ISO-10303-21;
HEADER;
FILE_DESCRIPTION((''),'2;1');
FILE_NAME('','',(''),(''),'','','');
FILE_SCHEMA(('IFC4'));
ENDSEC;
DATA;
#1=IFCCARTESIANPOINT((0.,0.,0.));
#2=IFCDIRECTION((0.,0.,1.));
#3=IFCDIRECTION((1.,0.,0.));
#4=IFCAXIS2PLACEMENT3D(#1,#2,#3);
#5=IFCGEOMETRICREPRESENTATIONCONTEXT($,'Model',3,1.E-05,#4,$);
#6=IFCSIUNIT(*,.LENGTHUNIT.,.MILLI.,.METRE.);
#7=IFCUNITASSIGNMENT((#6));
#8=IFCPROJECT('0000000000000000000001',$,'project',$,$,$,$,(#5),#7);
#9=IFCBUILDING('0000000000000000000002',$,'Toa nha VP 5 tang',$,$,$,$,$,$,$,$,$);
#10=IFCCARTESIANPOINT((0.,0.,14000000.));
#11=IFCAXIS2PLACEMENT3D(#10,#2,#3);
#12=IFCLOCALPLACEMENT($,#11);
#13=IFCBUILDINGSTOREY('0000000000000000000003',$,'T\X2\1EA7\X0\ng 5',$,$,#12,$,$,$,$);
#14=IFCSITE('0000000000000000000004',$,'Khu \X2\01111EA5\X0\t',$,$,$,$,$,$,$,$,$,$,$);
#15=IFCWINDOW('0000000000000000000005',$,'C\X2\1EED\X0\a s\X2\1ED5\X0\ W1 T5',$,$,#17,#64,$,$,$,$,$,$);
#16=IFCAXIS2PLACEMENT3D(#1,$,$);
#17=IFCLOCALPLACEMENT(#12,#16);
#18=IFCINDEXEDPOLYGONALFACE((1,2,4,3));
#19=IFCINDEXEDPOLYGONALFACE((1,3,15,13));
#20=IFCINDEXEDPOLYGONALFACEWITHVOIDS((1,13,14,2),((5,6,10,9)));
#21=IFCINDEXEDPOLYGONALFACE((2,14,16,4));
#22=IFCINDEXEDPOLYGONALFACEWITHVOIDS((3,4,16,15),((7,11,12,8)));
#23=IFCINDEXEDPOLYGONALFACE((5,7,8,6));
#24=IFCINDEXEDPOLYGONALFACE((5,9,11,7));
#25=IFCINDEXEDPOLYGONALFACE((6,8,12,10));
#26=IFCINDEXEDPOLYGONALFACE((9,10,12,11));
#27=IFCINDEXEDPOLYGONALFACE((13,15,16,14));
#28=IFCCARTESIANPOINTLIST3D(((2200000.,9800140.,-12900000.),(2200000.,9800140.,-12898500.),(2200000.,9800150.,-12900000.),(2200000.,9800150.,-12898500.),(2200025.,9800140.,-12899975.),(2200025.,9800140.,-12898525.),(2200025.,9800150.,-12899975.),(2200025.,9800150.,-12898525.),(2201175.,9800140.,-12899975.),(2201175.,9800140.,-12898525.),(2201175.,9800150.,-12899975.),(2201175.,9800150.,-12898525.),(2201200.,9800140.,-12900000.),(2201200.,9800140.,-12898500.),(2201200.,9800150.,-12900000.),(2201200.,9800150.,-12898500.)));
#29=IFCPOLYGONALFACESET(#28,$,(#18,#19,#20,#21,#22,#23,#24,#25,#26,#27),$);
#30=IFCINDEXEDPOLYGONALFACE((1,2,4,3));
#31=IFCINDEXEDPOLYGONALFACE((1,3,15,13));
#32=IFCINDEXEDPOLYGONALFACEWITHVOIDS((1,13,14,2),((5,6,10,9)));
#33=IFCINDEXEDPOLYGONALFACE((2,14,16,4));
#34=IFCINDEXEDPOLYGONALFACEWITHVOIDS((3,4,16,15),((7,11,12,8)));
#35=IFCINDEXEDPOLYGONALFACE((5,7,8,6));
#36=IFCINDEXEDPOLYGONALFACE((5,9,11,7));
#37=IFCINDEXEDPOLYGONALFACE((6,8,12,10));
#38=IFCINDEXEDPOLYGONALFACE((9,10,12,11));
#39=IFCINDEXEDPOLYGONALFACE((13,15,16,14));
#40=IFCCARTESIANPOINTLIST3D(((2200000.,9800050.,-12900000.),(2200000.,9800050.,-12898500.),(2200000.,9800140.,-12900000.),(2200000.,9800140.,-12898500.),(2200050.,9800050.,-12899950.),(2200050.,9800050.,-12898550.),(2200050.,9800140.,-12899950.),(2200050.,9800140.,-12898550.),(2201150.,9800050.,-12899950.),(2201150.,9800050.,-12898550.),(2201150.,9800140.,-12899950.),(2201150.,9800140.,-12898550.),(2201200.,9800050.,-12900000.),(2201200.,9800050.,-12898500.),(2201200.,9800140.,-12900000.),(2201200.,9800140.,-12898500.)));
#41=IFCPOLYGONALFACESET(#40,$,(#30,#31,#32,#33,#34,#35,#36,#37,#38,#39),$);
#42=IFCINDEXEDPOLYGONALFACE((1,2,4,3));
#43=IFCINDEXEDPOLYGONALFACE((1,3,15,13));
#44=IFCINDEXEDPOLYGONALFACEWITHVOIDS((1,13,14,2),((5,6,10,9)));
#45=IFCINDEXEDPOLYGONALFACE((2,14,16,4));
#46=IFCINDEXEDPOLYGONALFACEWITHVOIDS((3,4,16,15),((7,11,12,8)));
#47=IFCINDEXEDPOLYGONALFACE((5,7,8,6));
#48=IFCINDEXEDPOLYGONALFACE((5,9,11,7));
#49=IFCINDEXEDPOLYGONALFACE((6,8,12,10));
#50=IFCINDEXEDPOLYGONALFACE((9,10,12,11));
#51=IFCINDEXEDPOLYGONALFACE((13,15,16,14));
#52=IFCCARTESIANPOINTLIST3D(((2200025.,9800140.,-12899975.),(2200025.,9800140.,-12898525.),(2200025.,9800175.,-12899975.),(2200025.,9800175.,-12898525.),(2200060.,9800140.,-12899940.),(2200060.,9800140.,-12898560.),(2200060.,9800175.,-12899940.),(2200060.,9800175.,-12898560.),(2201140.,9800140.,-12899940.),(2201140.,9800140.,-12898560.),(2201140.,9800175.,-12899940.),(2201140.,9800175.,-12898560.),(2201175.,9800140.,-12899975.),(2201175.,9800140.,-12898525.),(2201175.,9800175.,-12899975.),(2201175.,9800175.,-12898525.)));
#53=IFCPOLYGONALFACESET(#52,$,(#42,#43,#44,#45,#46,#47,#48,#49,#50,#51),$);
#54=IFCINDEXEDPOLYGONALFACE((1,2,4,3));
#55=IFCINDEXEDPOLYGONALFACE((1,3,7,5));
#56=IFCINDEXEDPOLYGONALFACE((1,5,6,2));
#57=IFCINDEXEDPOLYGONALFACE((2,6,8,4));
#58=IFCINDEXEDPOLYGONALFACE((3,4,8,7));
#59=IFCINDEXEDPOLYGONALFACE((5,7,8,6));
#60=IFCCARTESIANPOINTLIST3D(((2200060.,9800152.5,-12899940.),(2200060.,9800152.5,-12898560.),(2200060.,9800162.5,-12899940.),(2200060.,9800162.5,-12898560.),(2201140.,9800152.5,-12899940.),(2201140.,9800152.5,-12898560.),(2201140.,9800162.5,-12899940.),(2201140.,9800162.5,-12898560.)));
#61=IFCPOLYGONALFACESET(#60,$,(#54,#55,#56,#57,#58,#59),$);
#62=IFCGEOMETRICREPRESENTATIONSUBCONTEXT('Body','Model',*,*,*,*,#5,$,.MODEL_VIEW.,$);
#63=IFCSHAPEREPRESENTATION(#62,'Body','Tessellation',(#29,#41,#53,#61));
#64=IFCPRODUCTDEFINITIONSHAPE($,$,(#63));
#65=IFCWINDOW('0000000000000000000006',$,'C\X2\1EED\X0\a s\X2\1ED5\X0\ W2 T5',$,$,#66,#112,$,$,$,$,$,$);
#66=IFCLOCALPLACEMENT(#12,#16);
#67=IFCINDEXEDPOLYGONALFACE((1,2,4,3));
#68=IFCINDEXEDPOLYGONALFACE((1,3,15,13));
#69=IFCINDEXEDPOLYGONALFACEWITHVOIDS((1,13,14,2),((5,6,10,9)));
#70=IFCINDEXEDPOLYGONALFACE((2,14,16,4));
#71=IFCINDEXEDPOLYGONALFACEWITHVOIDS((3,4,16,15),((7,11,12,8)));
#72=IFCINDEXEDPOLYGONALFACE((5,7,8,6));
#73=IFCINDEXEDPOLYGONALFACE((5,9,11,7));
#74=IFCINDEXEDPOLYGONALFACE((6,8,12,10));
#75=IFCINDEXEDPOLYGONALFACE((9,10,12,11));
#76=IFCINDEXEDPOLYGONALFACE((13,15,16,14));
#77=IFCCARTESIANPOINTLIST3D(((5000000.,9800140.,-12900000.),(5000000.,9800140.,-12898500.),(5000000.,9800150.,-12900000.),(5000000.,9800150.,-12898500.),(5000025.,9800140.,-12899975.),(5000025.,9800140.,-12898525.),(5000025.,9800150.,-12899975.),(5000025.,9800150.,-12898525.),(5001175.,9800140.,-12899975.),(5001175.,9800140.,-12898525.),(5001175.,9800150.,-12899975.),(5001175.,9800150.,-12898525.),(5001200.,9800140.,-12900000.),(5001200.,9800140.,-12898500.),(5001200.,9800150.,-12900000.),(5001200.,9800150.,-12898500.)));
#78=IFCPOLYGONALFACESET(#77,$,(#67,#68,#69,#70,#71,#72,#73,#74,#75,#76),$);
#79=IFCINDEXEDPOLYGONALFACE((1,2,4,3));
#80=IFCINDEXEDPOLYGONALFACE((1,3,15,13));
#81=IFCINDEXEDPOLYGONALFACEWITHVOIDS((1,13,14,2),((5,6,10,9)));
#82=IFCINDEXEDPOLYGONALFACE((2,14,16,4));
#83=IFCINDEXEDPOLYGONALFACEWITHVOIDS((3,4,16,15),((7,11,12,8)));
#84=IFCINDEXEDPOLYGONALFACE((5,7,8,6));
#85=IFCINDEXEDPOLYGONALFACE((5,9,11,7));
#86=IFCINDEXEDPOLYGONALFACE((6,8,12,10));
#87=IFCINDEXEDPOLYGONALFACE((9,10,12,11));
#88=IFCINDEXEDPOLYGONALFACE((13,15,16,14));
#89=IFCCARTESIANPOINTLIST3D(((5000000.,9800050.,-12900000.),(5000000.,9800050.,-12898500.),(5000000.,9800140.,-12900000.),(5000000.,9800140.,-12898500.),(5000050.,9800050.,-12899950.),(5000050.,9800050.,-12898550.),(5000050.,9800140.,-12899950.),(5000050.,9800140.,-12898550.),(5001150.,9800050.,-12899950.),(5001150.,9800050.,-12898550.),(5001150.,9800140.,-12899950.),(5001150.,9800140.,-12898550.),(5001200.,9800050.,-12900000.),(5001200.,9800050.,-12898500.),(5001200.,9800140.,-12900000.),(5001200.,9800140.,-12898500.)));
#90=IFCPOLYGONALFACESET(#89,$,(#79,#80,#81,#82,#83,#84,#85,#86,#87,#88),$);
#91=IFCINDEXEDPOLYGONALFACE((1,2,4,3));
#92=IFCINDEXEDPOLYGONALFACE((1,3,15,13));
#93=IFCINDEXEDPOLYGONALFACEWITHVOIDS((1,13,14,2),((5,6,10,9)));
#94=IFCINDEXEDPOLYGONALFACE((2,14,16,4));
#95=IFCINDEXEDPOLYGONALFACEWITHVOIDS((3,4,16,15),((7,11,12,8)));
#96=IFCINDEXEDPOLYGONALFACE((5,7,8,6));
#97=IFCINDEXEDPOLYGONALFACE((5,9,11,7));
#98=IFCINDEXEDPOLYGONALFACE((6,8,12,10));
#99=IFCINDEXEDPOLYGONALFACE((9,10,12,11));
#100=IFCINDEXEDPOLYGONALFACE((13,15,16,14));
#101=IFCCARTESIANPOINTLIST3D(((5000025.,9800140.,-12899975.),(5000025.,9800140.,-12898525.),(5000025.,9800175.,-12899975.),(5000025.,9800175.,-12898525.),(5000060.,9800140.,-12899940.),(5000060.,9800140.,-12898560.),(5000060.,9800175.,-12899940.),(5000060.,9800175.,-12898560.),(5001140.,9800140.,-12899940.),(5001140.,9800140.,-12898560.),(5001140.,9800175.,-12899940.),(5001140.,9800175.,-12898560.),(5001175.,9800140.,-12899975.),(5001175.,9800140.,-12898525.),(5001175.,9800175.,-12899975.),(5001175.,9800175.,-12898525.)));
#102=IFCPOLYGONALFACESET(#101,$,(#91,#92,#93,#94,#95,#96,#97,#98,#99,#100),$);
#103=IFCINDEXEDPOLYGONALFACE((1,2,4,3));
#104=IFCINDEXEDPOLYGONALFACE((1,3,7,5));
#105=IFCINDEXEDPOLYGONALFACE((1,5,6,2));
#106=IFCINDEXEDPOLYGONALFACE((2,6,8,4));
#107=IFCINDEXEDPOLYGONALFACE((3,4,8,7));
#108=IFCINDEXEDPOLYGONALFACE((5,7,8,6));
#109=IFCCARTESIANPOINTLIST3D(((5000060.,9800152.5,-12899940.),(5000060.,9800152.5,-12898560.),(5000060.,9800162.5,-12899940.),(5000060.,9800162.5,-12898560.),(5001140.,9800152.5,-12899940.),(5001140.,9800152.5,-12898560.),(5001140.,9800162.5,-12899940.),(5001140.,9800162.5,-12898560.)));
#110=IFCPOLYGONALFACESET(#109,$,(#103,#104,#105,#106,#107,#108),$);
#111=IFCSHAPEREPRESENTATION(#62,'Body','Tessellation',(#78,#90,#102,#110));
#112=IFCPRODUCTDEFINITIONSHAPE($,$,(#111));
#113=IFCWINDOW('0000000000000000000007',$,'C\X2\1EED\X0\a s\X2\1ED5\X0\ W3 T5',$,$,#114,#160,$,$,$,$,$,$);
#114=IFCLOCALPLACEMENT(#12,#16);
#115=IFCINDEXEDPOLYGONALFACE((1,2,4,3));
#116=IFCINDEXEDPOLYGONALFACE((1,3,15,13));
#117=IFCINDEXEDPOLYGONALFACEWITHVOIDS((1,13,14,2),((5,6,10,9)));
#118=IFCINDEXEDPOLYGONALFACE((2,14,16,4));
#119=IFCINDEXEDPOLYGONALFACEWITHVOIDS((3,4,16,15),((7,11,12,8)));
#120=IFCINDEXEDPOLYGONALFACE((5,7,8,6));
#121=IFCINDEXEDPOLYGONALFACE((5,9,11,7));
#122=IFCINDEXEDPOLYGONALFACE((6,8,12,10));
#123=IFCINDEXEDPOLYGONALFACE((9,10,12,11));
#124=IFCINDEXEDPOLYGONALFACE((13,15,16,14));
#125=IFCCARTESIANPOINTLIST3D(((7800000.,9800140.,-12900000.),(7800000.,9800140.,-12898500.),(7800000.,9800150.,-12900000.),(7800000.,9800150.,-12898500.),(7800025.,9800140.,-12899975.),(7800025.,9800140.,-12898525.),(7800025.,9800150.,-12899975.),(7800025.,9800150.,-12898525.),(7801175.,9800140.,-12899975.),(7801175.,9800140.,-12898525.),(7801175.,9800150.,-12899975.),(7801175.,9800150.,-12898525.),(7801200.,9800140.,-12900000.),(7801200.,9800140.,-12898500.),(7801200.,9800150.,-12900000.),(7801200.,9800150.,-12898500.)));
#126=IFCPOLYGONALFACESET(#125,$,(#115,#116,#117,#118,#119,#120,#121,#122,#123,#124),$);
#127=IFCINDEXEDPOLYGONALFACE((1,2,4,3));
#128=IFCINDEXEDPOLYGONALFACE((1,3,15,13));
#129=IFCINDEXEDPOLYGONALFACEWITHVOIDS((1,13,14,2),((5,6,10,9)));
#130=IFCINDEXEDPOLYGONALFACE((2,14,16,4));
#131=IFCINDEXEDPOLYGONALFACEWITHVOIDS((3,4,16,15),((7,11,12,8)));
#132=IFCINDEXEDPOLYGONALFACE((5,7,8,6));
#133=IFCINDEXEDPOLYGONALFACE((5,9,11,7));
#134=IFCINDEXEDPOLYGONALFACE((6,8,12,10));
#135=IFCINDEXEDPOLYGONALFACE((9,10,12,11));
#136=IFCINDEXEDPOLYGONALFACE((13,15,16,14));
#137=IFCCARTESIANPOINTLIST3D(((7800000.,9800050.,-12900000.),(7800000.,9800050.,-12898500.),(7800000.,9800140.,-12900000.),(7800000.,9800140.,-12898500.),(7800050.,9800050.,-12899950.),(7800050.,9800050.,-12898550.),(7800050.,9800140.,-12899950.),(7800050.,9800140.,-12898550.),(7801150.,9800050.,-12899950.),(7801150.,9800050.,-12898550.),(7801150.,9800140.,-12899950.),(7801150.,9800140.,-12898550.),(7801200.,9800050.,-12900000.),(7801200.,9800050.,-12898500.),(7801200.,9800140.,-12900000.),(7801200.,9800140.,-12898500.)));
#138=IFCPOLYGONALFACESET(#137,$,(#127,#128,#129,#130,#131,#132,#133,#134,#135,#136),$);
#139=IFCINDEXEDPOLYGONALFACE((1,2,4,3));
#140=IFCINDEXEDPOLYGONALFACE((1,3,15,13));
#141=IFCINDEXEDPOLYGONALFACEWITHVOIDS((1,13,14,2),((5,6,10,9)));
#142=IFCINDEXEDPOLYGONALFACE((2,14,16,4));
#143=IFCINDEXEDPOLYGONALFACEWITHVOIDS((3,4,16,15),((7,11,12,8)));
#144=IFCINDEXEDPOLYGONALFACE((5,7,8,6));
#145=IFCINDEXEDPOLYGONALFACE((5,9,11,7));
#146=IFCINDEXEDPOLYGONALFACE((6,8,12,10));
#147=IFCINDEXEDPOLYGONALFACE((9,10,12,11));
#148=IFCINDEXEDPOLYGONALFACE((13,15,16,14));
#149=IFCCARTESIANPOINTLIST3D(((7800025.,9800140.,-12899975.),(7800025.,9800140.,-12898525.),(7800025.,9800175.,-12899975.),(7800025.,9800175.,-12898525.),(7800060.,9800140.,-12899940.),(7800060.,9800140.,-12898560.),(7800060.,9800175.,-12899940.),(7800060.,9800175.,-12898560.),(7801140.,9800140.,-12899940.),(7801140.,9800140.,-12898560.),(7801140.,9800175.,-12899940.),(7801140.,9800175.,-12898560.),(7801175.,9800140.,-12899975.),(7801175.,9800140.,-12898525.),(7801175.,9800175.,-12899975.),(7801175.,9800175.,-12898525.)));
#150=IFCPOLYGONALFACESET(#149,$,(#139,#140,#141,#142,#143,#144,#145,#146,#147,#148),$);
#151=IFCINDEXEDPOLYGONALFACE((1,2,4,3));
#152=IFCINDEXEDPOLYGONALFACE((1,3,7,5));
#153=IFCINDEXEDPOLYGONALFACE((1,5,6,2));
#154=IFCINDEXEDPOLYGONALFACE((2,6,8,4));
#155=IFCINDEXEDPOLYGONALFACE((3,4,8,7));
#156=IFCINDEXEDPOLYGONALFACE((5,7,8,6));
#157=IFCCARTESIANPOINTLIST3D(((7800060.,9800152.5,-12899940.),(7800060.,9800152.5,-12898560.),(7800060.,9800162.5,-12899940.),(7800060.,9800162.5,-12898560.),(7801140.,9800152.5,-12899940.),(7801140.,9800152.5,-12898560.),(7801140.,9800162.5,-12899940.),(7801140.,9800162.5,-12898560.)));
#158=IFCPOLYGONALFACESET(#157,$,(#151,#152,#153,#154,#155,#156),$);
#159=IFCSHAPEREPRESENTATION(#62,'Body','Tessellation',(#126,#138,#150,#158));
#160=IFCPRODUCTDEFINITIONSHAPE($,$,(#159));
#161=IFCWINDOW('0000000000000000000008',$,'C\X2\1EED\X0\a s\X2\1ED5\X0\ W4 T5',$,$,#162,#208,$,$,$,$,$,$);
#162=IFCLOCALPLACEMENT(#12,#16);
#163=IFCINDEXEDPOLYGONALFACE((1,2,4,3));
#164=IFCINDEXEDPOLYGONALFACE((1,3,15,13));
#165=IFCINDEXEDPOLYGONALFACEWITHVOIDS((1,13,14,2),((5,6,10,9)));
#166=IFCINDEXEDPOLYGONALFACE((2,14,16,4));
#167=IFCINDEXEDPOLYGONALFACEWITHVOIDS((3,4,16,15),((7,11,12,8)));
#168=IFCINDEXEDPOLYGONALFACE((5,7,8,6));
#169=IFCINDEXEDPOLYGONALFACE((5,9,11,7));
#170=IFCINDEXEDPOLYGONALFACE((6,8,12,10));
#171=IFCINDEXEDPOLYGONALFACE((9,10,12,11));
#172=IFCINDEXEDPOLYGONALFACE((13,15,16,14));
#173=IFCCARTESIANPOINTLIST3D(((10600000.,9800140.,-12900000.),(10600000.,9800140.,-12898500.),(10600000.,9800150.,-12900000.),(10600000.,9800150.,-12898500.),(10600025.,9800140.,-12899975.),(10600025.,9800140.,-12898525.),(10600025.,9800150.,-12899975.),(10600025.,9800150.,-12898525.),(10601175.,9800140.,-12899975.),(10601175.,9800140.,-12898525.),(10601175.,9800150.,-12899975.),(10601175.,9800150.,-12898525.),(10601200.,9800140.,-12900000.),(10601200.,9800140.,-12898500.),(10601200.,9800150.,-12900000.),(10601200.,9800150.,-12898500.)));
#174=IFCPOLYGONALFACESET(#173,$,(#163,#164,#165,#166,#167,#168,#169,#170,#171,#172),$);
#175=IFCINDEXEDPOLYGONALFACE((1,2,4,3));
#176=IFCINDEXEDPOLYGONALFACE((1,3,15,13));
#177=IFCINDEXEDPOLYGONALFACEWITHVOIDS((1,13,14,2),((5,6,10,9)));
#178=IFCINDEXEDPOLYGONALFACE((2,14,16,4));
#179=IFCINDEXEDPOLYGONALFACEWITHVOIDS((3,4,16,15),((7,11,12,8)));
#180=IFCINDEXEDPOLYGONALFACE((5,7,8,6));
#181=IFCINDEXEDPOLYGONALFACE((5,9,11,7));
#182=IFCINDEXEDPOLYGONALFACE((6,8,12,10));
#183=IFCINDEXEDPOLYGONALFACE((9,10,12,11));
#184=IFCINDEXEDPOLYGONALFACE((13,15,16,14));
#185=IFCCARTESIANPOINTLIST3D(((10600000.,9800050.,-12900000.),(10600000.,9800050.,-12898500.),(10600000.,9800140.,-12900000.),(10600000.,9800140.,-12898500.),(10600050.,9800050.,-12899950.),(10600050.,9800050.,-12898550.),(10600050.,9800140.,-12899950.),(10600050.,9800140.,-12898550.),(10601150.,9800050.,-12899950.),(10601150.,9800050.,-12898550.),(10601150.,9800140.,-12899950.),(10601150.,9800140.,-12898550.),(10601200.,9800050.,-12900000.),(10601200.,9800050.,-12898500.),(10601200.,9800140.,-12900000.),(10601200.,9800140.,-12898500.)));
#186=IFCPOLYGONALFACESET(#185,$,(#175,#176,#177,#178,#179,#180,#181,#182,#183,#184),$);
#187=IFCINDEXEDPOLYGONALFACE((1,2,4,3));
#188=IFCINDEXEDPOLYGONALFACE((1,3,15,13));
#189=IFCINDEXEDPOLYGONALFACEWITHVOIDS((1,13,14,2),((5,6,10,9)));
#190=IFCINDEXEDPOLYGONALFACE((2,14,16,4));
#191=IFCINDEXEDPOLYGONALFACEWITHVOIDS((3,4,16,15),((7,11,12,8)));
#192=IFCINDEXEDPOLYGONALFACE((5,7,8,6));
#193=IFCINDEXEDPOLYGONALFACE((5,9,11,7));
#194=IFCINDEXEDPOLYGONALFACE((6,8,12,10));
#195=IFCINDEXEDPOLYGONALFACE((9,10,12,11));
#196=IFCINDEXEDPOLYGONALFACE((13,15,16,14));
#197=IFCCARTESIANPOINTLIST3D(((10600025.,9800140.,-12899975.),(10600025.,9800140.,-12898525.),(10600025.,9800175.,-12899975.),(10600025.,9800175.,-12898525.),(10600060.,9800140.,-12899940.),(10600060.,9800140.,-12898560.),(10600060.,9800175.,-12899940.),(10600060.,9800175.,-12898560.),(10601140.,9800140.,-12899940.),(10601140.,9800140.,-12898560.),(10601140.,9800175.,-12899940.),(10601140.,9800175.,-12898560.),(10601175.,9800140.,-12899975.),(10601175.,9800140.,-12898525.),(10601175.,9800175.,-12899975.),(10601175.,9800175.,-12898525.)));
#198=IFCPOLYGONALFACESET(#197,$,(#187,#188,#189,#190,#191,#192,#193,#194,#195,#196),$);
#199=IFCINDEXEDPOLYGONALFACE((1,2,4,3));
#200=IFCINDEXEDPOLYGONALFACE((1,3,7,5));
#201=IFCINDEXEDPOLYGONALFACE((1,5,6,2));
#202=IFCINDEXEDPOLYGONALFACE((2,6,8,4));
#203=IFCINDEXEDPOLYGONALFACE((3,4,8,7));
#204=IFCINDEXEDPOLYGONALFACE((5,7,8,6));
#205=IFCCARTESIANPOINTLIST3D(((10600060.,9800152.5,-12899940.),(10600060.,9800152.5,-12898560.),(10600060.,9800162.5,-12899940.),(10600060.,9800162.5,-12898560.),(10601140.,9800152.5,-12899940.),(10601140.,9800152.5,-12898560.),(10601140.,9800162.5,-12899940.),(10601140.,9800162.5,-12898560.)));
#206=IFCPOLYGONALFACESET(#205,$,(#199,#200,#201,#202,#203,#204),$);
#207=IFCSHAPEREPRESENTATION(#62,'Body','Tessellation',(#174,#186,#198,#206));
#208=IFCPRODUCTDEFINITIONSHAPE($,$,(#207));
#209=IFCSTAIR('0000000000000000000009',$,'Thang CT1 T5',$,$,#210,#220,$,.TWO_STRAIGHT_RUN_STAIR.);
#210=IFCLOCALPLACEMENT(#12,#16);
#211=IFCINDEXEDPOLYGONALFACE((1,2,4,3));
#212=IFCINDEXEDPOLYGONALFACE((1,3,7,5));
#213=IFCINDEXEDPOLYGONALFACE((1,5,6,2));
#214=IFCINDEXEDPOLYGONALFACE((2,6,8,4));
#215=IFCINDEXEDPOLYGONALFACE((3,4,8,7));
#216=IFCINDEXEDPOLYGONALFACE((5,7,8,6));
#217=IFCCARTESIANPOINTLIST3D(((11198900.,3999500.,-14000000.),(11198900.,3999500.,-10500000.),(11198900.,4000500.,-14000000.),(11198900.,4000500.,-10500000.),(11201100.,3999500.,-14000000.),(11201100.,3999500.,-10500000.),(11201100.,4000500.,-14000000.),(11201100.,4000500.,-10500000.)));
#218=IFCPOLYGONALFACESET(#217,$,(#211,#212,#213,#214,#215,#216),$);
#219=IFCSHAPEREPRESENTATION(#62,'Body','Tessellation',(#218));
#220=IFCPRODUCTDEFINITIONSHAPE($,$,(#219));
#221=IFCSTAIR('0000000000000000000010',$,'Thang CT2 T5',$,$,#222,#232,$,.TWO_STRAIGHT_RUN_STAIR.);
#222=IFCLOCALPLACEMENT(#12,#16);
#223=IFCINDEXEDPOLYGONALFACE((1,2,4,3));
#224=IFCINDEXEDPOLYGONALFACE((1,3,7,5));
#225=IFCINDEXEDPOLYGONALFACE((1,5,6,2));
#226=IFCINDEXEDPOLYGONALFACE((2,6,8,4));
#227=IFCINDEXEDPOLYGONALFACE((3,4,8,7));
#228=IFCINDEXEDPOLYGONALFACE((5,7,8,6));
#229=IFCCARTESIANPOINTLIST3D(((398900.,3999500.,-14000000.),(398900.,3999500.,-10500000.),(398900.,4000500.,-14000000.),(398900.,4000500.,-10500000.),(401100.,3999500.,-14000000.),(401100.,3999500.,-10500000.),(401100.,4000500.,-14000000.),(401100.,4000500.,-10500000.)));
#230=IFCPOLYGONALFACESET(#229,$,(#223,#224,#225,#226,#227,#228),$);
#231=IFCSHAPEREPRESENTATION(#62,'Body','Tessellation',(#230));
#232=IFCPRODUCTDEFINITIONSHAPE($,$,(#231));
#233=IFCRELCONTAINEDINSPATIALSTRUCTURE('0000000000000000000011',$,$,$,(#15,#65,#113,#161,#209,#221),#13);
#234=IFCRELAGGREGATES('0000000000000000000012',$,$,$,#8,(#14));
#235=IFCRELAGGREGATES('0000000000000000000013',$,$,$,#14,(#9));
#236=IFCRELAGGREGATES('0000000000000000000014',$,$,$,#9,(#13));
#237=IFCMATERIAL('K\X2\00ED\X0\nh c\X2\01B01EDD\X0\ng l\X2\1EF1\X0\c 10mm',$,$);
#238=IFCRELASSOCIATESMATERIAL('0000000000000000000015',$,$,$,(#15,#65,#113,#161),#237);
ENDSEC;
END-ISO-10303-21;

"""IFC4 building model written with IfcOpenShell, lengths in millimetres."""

from ifc_helpers import new_model, entity, si_unit, frame, origin_with_axes, place, context, subcontext, project, spatial, line, indexed_curve, outline, extrude, material, element, save


model = new_model("IFC4")

# Units and contexts
model_context = context("Model", 3, precision=1e-05, world=origin_with_axes())
body_context = subcontext(model_context, "Body", "Model", "MODEL_VIEW")
ifc_project = project(units=[si_unit("LENGTHUNIT", "METRE", prefix="MILLI")], contexts=[model_context])

# Site, building, storey
site = spatial("IfcSite", under=ifc_project, Name="Khu đất")
building = spatial("IfcBuilding", under=site, Name="Toa nha VP 5 tang")
storey_placement = place(None, frame((0.0, 0.0, 14000000.0), z_axis=(0.0, 0.0, 1.0), x_axis=(1.0, 0.0, 0.0)))
storey = spatial("IfcBuildingStorey", under=building, at=storey_placement, Name="Tầng 5")

# Windows
ifc_material_1 = material(Name="Kính cường lực 10mm")
for number, where, z_axis, x_axis, name in (
    (1, (2200000.0, 9800000.0, -12900000.0), (0.0, 0.0, 1.0), (1.0, 0.0, 0.0), "Cửa sổ W1 T5"),
    (2, (5000000.0, 9800000.0, -12900000.0), (0.0, 0.0, 1.0), (1.0, 0.0, 0.0), "Cửa sổ W2 T5"),
    (3, (7800000.0, 9800000.0, -12900000.0), (0.0, 0.0, 1.0), (1.0, 0.0, 0.0), "Cửa sổ W3 T5"),
    (4, (10600000.0, 9800000.0, -12900000.0), (0.0, 0.0, 1.0), (1.0, 0.0, 0.0), "Cửa sổ W4 T5"),
):
    element("IfcWindow", number, at=place(storey_placement, frame(where, z_axis=z_axis, x_axis=x_axis)), inside=storey, material=ifc_material_1, Name=name, context=body_context, shape_type="SolidModel", body=[
        extrude(outline(indexed_curve([(0.0, 0.0), (1200.0, 0.0), (1200.0, 1500.0), (0.0, 1500.0)], segments=[line(1, 2, 3, 4, 1)]), holes=[indexed_curve([(25.0, 25.0), (1175.0, 25.0), (1175.0, 1475.0), (25.0, 1475.0)], segments=[line(1, 2, 3, 4, 1)])]), frame((0.0, 140.0, 0.0), z_axis=(0.0, -1.0, 0.0), x_axis=(1.0, 0.0, 0.0)), (0.0, 0.0, -1.0), 10.0),
        extrude(outline(indexed_curve([(0.0, 0.0), (1200.0, 0.0), (1200.0, 1500.0), (0.0, 1500.0)], segments=[line(1, 2, 3, 4, 1)]), holes=[indexed_curve([(50.0, 50.0), (1150.0, 50.0), (1150.0, 1450.0), (50.0, 1450.0)], segments=[line(1, 2, 3, 4, 1)])]), frame((0.0, 50.0, 0.0), z_axis=(0.0, -1.0, 0.0), x_axis=(1.0, 0.0, 0.0)), (0.0, 0.0, -1.0), 90.0),
        extrude(outline(indexed_curve([(0.0, 0.0), (1150.0, 0.0), (1150.0, 1450.0), (0.0, 1450.0)], segments=[line(1, 2, 3, 4, 1)]), holes=[indexed_curve([(35.0, 35.0), (1115.0, 35.0), (1115.0, 1415.0), (35.0, 1415.0)], segments=[line(1, 2, 3, 4, 1)])]), frame((25.0, 140.0, 25.0), z_axis=(0.0, -1.0, 0.0), x_axis=(1.0, 0.0, 0.0)), (0.0, 0.0, -1.0), 35.0),
        extrude(outline(indexed_curve([(35.0, 35.0), (1115.0, 35.0), (1115.0, 1415.0), (35.0, 1415.0)], segments=[line(1, 2, 3, 4, 1)])), frame((25.0, 152.5, 25.0), z_axis=(0.0, -1.0, 0.0), x_axis=(1.0, 0.0, 0.0)), (0.0, 0.0, -1.0), 10.0),
    ])

# Stairs
for number, where, z_axis, x_axis, name in (
    (5, (11200000.0, 4000000.0, -14000000.0), (0.0, 0.0, 1.0), (1.0, 0.0, 0.0), "Thang CT1 T5"),
    (6, (400000.0, 4000000.0, -14000000.0), (0.0, 0.0, 1.0), (1.0, 0.0, 0.0), "Thang CT2 T5"),
):
    element("IfcStair", number, at=place(storey_placement, frame(where, z_axis=z_axis, x_axis=x_axis)), inside=storey, Name=name, PredefinedType="TWO_STRAIGHT_RUN_STAIR", context=body_context, shape_type="SweptSolid", body=[
        extrude(entity("IfcRectangleProfileDef", None, None, None, 2200.0, 1000.0), origin_with_axes(), (0.0, 0.0, 1.0), 3500000.0),
    ])

save(model, "model.ifc")
